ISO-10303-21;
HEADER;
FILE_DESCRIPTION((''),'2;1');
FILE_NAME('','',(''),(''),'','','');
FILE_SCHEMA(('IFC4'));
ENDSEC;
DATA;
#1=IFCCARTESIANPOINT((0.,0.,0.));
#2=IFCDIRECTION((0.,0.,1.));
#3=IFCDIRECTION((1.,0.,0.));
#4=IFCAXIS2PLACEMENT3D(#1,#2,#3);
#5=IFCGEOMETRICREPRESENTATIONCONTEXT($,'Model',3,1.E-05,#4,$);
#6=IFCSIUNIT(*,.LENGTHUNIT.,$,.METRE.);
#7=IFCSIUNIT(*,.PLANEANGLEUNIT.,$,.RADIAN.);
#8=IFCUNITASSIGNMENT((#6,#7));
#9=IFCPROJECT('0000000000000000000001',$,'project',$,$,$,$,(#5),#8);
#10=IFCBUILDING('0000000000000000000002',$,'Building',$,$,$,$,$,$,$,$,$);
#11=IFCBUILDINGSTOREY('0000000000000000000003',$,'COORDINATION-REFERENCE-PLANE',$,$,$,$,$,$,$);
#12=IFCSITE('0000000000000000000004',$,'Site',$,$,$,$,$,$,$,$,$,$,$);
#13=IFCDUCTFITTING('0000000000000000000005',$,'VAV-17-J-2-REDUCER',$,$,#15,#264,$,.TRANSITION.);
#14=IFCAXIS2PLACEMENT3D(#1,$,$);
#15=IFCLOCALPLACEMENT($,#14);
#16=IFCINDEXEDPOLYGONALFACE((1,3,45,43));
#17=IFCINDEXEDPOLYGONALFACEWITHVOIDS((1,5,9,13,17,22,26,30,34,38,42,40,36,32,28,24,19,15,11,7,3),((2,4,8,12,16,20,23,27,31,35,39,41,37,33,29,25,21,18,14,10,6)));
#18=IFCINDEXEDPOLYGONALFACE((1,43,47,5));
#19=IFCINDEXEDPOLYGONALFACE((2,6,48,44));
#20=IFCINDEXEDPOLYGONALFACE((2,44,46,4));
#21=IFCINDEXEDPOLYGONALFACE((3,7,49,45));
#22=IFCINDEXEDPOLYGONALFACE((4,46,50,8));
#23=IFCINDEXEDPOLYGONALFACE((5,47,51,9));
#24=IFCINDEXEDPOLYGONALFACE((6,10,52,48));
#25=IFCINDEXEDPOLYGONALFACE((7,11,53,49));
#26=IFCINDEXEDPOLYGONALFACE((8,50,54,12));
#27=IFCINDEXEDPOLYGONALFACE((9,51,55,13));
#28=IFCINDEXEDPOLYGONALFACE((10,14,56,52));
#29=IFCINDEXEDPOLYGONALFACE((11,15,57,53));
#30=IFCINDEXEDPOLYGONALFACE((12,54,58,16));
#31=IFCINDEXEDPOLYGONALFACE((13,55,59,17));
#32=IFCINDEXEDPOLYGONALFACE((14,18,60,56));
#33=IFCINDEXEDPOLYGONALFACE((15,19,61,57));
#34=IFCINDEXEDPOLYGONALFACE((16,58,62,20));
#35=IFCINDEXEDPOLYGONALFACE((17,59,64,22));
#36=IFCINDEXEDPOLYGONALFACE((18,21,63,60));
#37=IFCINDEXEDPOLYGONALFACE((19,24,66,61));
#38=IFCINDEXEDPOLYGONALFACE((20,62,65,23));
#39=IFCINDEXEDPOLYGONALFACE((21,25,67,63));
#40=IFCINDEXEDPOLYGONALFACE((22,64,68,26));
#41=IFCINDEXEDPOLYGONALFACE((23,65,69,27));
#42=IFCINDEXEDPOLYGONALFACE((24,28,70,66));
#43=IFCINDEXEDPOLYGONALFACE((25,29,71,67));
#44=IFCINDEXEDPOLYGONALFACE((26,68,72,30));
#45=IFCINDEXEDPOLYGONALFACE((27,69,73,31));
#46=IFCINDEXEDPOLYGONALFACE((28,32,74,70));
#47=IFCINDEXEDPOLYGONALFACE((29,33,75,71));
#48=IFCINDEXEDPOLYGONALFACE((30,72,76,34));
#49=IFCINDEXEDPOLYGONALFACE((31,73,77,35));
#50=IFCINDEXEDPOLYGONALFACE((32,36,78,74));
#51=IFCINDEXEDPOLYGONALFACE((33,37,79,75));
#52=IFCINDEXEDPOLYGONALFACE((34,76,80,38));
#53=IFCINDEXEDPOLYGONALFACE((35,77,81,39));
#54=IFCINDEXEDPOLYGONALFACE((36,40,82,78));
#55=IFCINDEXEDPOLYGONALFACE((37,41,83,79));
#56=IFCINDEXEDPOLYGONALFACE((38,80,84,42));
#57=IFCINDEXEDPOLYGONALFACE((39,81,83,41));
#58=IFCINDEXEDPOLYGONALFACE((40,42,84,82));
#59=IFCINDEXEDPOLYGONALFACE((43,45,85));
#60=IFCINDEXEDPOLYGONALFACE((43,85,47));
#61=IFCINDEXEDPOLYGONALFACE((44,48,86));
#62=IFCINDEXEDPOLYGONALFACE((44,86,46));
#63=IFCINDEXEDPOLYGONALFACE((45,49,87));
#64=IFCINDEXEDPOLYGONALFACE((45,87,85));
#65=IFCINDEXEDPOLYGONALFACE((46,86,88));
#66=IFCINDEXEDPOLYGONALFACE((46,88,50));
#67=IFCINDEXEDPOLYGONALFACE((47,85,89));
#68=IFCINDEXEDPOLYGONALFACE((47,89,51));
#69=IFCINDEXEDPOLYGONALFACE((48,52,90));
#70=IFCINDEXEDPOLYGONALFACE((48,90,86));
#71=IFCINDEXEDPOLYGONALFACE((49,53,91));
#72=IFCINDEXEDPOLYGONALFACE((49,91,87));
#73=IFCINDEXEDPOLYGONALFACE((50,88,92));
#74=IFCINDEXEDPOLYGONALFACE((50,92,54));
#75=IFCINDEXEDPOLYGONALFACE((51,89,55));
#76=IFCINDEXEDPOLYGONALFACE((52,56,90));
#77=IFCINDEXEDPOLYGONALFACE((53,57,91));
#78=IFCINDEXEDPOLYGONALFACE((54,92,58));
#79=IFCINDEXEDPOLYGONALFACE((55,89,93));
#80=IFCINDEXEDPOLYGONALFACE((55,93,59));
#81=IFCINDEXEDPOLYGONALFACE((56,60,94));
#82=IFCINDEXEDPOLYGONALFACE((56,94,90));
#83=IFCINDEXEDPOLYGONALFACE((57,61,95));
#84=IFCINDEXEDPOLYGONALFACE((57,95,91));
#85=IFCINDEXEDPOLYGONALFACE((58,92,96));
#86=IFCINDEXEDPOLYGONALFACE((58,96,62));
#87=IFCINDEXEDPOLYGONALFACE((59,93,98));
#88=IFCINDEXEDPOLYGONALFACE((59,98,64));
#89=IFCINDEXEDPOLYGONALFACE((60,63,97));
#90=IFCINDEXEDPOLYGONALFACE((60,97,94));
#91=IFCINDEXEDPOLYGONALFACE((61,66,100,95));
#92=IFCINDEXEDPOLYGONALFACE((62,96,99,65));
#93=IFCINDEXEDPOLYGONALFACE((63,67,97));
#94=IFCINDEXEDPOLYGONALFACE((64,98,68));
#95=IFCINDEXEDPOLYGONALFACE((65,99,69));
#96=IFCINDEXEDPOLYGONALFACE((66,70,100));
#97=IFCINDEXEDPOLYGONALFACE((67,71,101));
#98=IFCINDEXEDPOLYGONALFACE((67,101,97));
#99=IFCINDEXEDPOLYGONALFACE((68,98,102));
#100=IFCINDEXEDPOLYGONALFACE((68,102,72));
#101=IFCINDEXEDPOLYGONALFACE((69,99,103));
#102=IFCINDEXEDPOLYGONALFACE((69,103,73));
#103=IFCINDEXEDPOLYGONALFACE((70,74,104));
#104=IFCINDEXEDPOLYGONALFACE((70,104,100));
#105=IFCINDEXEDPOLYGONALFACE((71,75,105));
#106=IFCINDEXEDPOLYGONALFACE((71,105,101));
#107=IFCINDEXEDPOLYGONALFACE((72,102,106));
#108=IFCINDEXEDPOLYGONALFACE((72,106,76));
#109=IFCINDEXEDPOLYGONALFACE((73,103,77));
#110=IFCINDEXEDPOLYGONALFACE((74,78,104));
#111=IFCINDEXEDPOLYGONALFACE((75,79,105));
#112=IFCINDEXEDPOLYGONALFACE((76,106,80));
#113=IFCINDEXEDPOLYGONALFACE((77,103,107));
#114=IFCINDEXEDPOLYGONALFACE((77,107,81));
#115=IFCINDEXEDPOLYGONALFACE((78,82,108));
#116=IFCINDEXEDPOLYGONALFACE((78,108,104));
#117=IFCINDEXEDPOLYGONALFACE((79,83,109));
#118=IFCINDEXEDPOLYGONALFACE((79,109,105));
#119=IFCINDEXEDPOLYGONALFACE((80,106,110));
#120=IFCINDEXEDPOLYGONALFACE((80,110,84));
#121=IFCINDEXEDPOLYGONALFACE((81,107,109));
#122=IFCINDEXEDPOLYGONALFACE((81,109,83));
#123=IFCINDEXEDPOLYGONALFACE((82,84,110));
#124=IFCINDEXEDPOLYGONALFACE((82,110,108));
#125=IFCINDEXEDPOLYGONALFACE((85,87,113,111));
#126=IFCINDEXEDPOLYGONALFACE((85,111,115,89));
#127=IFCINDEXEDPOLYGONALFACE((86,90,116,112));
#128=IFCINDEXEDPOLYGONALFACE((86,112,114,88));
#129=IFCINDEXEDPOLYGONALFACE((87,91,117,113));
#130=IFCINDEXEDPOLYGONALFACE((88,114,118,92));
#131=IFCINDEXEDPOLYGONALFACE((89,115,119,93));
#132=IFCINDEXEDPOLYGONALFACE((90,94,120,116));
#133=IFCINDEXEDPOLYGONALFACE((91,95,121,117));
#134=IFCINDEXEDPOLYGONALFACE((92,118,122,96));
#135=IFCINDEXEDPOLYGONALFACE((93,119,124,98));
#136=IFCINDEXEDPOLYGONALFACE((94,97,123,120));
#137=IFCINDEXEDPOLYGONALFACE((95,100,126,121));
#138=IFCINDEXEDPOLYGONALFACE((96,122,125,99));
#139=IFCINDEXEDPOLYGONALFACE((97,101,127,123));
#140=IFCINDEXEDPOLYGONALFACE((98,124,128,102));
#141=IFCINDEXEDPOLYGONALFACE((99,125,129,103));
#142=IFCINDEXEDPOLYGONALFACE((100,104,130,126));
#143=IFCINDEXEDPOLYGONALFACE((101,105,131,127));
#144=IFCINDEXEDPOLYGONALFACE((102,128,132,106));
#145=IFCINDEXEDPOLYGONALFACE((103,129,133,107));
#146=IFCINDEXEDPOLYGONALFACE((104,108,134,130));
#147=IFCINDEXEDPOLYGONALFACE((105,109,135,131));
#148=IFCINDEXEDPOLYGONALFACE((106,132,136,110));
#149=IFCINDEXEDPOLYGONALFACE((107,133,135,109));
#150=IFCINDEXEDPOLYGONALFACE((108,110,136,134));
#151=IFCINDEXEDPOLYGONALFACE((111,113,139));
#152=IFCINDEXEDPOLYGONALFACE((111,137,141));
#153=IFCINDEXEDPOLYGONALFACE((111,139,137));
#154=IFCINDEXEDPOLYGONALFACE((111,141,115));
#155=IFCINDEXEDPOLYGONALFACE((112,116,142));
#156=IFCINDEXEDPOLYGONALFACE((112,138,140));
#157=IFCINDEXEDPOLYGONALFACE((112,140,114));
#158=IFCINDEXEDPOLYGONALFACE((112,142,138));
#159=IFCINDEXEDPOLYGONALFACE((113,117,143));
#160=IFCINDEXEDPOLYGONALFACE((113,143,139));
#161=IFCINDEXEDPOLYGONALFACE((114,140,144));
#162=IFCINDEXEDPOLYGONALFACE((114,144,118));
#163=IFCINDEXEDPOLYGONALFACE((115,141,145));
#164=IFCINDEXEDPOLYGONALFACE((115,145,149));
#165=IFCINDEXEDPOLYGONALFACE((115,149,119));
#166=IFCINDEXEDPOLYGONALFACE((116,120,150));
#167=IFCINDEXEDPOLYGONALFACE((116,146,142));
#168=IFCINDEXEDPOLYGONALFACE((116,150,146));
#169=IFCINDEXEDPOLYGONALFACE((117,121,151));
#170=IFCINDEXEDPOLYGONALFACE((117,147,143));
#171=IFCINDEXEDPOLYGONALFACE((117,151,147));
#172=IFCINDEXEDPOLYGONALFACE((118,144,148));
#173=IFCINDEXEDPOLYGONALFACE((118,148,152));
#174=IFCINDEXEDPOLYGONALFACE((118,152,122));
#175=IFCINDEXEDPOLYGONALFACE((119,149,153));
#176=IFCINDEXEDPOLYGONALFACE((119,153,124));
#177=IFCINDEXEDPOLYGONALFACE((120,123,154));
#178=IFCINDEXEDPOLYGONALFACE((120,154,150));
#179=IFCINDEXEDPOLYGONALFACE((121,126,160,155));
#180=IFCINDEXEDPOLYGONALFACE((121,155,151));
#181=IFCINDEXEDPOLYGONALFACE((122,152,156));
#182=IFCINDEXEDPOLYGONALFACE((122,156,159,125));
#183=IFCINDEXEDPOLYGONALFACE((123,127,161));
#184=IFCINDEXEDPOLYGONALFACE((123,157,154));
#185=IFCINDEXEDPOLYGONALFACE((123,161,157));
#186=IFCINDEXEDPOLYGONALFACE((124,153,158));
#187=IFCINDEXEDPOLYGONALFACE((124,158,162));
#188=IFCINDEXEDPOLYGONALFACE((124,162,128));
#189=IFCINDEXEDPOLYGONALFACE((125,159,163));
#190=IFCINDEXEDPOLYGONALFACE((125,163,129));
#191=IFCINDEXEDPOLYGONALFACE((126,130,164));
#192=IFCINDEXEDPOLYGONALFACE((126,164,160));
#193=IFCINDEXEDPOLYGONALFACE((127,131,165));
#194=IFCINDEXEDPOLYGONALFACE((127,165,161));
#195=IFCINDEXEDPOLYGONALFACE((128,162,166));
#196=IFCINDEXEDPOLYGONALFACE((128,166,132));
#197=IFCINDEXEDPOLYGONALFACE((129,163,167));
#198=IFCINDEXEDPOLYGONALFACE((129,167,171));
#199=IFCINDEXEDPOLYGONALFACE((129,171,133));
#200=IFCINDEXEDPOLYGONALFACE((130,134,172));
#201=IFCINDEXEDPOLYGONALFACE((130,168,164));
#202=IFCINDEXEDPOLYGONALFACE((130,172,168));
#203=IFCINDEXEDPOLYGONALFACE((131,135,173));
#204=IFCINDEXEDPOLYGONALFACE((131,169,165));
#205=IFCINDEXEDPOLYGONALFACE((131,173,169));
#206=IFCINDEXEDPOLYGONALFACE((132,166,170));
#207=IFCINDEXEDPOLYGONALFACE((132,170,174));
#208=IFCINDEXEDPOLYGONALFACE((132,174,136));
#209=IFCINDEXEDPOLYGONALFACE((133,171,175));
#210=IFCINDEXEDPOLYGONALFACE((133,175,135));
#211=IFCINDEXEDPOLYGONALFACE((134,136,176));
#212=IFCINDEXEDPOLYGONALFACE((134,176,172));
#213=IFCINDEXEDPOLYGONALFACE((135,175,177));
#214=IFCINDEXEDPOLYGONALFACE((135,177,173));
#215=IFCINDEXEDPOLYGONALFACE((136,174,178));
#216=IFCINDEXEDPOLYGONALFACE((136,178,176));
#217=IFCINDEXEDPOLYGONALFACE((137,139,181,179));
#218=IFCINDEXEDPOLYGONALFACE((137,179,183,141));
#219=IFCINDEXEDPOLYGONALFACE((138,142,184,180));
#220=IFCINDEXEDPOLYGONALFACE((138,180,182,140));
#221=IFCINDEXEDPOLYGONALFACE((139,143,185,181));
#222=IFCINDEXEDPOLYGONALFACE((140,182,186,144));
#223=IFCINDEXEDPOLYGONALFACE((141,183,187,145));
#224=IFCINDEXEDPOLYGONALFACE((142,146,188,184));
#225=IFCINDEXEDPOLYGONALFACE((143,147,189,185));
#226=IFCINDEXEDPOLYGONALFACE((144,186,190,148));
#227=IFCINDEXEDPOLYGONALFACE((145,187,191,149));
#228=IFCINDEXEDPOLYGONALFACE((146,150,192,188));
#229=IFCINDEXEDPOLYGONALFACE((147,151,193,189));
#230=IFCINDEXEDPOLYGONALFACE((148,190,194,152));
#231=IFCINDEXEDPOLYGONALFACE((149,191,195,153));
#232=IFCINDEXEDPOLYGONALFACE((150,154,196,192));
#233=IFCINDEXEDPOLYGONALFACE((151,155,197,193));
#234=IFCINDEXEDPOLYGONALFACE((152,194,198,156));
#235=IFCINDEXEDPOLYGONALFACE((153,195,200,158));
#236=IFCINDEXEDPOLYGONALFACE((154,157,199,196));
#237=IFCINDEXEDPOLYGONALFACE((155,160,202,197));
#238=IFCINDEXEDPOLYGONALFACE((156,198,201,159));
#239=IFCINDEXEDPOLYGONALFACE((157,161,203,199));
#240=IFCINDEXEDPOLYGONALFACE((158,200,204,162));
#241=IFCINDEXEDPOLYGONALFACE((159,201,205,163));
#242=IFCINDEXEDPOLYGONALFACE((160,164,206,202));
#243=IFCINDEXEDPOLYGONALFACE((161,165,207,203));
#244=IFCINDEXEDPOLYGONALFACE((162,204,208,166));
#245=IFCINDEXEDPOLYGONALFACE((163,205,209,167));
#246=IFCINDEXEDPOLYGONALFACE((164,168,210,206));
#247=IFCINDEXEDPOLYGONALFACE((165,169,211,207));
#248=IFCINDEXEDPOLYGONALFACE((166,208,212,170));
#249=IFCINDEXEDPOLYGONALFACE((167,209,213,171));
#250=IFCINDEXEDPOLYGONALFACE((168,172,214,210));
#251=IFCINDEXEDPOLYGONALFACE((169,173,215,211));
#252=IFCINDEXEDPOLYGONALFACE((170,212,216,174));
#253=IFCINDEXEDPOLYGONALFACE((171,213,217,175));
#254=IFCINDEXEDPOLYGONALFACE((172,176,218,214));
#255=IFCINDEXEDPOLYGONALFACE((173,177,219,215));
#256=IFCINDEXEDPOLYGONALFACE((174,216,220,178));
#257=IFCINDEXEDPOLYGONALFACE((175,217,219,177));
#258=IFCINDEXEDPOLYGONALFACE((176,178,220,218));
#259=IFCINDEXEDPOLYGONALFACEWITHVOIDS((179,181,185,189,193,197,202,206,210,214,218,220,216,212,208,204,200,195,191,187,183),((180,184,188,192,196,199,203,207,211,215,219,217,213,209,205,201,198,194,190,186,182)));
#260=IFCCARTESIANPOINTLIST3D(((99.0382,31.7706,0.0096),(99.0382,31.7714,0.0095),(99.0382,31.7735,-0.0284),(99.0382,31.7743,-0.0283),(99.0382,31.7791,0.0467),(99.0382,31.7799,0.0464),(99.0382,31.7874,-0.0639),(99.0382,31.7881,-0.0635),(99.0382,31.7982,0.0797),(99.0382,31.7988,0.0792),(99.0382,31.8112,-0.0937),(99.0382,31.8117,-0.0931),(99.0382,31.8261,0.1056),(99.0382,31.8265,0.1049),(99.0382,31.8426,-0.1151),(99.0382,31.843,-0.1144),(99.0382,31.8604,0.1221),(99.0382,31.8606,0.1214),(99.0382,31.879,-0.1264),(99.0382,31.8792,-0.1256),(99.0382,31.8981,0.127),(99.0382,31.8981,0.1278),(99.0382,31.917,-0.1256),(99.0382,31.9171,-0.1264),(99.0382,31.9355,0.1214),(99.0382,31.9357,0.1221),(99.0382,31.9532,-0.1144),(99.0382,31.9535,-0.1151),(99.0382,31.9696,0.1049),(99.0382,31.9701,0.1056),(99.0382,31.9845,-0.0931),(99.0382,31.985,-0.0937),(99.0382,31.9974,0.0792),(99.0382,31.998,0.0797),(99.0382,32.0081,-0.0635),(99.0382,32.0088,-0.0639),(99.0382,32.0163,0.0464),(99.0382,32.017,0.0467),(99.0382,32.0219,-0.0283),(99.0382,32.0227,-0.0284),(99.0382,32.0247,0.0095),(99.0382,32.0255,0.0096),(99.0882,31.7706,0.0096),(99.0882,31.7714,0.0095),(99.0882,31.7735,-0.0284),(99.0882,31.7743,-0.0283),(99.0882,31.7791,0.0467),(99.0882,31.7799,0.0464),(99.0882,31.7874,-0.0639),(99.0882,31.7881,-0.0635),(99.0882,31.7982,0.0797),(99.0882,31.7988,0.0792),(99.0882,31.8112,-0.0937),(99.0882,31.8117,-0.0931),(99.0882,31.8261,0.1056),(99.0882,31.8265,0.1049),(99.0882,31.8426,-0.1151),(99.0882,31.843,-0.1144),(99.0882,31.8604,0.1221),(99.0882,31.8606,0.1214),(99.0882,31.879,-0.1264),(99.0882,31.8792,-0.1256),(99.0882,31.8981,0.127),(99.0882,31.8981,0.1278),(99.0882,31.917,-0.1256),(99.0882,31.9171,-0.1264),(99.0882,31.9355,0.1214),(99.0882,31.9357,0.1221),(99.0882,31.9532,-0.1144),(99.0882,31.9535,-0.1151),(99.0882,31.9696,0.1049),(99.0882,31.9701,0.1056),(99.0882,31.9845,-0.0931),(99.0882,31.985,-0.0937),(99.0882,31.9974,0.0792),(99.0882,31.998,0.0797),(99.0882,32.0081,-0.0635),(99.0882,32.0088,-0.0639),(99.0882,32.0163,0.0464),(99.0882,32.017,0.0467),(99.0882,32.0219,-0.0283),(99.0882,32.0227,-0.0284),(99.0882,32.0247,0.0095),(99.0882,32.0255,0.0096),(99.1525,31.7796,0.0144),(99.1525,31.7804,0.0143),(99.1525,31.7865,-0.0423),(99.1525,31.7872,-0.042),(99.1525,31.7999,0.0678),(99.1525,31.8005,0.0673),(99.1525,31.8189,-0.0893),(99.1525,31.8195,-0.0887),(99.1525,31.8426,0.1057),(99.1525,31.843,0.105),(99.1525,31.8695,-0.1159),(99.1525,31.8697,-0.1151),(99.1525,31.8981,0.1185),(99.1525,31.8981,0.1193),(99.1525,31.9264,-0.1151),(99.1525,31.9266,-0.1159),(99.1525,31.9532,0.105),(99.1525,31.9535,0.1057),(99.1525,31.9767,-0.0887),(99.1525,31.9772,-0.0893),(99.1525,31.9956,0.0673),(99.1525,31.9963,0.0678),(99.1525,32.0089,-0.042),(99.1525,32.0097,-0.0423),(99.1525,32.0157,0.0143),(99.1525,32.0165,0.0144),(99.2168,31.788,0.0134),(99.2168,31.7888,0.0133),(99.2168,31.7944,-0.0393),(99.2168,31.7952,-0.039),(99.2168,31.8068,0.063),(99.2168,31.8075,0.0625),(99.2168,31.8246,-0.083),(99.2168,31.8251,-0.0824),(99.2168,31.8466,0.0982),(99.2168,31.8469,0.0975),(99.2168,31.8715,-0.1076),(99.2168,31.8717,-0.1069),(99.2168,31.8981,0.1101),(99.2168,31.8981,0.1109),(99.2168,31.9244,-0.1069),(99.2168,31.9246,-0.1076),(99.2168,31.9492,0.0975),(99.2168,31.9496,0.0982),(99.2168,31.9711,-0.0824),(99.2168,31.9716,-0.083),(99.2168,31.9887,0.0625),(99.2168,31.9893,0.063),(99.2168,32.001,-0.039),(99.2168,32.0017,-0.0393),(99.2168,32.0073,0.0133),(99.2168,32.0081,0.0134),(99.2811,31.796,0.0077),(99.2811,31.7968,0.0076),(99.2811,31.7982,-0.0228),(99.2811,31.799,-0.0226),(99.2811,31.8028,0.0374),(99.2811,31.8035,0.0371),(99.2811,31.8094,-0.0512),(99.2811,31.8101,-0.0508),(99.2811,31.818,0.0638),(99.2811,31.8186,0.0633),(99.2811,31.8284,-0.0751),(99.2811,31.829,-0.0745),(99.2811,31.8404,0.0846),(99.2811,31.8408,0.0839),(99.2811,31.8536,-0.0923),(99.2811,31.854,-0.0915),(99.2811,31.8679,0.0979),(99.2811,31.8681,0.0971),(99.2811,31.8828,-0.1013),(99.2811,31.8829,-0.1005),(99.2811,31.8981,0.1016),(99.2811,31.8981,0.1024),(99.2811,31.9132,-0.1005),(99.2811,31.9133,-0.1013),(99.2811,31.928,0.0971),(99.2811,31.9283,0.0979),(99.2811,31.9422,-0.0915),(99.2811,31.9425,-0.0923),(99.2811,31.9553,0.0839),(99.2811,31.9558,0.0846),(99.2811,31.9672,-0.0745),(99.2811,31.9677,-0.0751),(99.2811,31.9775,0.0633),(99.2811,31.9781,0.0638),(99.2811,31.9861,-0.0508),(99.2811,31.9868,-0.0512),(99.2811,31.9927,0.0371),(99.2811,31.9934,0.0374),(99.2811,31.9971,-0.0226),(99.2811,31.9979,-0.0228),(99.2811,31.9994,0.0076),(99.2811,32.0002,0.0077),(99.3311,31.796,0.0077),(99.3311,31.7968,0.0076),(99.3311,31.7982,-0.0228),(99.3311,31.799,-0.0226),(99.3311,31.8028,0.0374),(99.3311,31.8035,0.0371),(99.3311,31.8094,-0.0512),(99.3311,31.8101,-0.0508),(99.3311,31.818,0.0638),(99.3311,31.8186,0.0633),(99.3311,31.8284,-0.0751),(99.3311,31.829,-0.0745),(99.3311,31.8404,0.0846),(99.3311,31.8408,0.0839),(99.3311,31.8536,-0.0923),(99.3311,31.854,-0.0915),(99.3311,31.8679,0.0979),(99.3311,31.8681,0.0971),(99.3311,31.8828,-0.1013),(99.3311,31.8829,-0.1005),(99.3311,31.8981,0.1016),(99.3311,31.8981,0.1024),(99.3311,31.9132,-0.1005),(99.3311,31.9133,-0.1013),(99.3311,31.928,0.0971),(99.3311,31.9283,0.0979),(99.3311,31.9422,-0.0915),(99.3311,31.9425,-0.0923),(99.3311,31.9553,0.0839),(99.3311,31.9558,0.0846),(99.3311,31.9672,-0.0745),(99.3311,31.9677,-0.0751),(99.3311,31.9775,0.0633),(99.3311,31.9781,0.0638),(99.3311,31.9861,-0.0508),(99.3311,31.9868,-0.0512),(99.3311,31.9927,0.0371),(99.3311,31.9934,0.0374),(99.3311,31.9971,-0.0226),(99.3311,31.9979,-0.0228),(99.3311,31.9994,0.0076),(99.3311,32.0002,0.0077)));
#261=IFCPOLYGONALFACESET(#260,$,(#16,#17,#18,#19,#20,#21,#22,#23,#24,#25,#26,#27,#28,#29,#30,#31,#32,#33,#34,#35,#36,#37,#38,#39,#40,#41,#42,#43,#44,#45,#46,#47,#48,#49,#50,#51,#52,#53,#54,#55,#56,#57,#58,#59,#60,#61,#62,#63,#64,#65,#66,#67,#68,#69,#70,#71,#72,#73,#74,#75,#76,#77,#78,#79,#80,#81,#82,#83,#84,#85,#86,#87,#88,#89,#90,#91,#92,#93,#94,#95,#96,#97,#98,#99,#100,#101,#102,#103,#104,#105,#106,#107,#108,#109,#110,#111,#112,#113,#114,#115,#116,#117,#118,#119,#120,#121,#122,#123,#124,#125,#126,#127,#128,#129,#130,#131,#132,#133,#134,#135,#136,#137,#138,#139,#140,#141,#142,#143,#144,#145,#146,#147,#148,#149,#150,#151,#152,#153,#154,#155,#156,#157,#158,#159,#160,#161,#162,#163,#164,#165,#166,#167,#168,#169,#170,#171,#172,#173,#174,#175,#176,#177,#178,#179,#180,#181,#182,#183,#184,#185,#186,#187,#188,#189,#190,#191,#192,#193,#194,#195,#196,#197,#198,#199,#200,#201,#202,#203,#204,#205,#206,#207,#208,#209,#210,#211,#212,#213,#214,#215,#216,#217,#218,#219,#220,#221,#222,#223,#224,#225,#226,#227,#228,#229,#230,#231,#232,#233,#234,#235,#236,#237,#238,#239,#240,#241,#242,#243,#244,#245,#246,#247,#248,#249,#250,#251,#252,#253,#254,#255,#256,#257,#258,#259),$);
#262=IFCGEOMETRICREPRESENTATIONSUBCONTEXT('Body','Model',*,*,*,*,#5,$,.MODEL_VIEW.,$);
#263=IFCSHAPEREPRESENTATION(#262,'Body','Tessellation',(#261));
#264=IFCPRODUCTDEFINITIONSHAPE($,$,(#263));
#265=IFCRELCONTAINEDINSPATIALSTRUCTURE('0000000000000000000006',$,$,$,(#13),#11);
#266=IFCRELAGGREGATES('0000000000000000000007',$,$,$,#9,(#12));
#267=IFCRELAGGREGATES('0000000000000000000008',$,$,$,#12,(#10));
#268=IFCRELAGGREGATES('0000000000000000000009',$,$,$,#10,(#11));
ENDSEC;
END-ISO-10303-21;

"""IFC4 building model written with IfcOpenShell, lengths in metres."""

from ifc_helpers import new_model, entity, si_unit, frame, origin_with_axes, place, context, subcontext, project, spatial, element, save


model = new_model("IFC4")

# Units and contexts
model_context = context("Model", 3, precision=1e-05, world=origin_with_axes())
body_context_1 = subcontext(model_context, "Body", "Model", "MODEL_VIEW")
ifc_project = project(units=[si_unit("LENGTHUNIT", "METRE"), si_unit("PLANEANGLEUNIT", "RADIAN")], contexts=[model_context])

# Site, building, storey
site = spatial("IfcSite", under=ifc_project, Name="Site")
building = spatial("IfcBuilding", under=site, Name="Building")
storey = spatial("IfcBuildingStorey", under=building, Name="COORDINATION-REFERENCE-PLANE")

# Duct fitting
for number, where, z_axis, x_axis, name in (
    (1, (99.0382, 31.8981, 0.0), (0.0, 1.0, 0.0), (0.0, 0.0, 1.0), "VAV-17-J-2-REDUCER"),
):
    element("IfcDuctFitting", number, at=place(None, frame(where, z_axis=z_axis, x_axis=x_axis)), inside=storey, Name=name, PredefinedType="TRANSITION", context=body_context_1, shape_type="SweptSolid", body=[
        entity("IfcRevolvedAreaSolid", entity("IfcArbitraryClosedProfileDef", "AREA", None, entity("IfcPolyline", [entity("IfcCartesianPoint", [0.1278, 0.0]), entity("IfcCartesianPoint", [0.1278, 0.05]), entity("IfcCartesianPoint", [0.1024, 0.2429]), entity("IfcCartesianPoint", [0.1024, 0.2929]), entity("IfcCartesianPoint", [0.1016, 0.2929]), entity("IfcCartesianPoint", [0.1016, 0.2429]), entity("IfcCartesianPoint", [0.127, 0.05]), entity("IfcCartesianPoint", [0.127, 0.0]), entity("IfcCartesianPoint", [0.1278, 0.0])])), entity("IfcAxis2Placement3D", entity("IfcCartesianPoint", [0.0, 0.0, 0.0])), entity("IfcAxis1Placement", entity("IfcCartesianPoint", [0.0, 0.0, 0.0]), entity("IfcDirection", [0.0, 1.0, 0.0])), 6.283185),
    ])

save(model, "model.ifc")
